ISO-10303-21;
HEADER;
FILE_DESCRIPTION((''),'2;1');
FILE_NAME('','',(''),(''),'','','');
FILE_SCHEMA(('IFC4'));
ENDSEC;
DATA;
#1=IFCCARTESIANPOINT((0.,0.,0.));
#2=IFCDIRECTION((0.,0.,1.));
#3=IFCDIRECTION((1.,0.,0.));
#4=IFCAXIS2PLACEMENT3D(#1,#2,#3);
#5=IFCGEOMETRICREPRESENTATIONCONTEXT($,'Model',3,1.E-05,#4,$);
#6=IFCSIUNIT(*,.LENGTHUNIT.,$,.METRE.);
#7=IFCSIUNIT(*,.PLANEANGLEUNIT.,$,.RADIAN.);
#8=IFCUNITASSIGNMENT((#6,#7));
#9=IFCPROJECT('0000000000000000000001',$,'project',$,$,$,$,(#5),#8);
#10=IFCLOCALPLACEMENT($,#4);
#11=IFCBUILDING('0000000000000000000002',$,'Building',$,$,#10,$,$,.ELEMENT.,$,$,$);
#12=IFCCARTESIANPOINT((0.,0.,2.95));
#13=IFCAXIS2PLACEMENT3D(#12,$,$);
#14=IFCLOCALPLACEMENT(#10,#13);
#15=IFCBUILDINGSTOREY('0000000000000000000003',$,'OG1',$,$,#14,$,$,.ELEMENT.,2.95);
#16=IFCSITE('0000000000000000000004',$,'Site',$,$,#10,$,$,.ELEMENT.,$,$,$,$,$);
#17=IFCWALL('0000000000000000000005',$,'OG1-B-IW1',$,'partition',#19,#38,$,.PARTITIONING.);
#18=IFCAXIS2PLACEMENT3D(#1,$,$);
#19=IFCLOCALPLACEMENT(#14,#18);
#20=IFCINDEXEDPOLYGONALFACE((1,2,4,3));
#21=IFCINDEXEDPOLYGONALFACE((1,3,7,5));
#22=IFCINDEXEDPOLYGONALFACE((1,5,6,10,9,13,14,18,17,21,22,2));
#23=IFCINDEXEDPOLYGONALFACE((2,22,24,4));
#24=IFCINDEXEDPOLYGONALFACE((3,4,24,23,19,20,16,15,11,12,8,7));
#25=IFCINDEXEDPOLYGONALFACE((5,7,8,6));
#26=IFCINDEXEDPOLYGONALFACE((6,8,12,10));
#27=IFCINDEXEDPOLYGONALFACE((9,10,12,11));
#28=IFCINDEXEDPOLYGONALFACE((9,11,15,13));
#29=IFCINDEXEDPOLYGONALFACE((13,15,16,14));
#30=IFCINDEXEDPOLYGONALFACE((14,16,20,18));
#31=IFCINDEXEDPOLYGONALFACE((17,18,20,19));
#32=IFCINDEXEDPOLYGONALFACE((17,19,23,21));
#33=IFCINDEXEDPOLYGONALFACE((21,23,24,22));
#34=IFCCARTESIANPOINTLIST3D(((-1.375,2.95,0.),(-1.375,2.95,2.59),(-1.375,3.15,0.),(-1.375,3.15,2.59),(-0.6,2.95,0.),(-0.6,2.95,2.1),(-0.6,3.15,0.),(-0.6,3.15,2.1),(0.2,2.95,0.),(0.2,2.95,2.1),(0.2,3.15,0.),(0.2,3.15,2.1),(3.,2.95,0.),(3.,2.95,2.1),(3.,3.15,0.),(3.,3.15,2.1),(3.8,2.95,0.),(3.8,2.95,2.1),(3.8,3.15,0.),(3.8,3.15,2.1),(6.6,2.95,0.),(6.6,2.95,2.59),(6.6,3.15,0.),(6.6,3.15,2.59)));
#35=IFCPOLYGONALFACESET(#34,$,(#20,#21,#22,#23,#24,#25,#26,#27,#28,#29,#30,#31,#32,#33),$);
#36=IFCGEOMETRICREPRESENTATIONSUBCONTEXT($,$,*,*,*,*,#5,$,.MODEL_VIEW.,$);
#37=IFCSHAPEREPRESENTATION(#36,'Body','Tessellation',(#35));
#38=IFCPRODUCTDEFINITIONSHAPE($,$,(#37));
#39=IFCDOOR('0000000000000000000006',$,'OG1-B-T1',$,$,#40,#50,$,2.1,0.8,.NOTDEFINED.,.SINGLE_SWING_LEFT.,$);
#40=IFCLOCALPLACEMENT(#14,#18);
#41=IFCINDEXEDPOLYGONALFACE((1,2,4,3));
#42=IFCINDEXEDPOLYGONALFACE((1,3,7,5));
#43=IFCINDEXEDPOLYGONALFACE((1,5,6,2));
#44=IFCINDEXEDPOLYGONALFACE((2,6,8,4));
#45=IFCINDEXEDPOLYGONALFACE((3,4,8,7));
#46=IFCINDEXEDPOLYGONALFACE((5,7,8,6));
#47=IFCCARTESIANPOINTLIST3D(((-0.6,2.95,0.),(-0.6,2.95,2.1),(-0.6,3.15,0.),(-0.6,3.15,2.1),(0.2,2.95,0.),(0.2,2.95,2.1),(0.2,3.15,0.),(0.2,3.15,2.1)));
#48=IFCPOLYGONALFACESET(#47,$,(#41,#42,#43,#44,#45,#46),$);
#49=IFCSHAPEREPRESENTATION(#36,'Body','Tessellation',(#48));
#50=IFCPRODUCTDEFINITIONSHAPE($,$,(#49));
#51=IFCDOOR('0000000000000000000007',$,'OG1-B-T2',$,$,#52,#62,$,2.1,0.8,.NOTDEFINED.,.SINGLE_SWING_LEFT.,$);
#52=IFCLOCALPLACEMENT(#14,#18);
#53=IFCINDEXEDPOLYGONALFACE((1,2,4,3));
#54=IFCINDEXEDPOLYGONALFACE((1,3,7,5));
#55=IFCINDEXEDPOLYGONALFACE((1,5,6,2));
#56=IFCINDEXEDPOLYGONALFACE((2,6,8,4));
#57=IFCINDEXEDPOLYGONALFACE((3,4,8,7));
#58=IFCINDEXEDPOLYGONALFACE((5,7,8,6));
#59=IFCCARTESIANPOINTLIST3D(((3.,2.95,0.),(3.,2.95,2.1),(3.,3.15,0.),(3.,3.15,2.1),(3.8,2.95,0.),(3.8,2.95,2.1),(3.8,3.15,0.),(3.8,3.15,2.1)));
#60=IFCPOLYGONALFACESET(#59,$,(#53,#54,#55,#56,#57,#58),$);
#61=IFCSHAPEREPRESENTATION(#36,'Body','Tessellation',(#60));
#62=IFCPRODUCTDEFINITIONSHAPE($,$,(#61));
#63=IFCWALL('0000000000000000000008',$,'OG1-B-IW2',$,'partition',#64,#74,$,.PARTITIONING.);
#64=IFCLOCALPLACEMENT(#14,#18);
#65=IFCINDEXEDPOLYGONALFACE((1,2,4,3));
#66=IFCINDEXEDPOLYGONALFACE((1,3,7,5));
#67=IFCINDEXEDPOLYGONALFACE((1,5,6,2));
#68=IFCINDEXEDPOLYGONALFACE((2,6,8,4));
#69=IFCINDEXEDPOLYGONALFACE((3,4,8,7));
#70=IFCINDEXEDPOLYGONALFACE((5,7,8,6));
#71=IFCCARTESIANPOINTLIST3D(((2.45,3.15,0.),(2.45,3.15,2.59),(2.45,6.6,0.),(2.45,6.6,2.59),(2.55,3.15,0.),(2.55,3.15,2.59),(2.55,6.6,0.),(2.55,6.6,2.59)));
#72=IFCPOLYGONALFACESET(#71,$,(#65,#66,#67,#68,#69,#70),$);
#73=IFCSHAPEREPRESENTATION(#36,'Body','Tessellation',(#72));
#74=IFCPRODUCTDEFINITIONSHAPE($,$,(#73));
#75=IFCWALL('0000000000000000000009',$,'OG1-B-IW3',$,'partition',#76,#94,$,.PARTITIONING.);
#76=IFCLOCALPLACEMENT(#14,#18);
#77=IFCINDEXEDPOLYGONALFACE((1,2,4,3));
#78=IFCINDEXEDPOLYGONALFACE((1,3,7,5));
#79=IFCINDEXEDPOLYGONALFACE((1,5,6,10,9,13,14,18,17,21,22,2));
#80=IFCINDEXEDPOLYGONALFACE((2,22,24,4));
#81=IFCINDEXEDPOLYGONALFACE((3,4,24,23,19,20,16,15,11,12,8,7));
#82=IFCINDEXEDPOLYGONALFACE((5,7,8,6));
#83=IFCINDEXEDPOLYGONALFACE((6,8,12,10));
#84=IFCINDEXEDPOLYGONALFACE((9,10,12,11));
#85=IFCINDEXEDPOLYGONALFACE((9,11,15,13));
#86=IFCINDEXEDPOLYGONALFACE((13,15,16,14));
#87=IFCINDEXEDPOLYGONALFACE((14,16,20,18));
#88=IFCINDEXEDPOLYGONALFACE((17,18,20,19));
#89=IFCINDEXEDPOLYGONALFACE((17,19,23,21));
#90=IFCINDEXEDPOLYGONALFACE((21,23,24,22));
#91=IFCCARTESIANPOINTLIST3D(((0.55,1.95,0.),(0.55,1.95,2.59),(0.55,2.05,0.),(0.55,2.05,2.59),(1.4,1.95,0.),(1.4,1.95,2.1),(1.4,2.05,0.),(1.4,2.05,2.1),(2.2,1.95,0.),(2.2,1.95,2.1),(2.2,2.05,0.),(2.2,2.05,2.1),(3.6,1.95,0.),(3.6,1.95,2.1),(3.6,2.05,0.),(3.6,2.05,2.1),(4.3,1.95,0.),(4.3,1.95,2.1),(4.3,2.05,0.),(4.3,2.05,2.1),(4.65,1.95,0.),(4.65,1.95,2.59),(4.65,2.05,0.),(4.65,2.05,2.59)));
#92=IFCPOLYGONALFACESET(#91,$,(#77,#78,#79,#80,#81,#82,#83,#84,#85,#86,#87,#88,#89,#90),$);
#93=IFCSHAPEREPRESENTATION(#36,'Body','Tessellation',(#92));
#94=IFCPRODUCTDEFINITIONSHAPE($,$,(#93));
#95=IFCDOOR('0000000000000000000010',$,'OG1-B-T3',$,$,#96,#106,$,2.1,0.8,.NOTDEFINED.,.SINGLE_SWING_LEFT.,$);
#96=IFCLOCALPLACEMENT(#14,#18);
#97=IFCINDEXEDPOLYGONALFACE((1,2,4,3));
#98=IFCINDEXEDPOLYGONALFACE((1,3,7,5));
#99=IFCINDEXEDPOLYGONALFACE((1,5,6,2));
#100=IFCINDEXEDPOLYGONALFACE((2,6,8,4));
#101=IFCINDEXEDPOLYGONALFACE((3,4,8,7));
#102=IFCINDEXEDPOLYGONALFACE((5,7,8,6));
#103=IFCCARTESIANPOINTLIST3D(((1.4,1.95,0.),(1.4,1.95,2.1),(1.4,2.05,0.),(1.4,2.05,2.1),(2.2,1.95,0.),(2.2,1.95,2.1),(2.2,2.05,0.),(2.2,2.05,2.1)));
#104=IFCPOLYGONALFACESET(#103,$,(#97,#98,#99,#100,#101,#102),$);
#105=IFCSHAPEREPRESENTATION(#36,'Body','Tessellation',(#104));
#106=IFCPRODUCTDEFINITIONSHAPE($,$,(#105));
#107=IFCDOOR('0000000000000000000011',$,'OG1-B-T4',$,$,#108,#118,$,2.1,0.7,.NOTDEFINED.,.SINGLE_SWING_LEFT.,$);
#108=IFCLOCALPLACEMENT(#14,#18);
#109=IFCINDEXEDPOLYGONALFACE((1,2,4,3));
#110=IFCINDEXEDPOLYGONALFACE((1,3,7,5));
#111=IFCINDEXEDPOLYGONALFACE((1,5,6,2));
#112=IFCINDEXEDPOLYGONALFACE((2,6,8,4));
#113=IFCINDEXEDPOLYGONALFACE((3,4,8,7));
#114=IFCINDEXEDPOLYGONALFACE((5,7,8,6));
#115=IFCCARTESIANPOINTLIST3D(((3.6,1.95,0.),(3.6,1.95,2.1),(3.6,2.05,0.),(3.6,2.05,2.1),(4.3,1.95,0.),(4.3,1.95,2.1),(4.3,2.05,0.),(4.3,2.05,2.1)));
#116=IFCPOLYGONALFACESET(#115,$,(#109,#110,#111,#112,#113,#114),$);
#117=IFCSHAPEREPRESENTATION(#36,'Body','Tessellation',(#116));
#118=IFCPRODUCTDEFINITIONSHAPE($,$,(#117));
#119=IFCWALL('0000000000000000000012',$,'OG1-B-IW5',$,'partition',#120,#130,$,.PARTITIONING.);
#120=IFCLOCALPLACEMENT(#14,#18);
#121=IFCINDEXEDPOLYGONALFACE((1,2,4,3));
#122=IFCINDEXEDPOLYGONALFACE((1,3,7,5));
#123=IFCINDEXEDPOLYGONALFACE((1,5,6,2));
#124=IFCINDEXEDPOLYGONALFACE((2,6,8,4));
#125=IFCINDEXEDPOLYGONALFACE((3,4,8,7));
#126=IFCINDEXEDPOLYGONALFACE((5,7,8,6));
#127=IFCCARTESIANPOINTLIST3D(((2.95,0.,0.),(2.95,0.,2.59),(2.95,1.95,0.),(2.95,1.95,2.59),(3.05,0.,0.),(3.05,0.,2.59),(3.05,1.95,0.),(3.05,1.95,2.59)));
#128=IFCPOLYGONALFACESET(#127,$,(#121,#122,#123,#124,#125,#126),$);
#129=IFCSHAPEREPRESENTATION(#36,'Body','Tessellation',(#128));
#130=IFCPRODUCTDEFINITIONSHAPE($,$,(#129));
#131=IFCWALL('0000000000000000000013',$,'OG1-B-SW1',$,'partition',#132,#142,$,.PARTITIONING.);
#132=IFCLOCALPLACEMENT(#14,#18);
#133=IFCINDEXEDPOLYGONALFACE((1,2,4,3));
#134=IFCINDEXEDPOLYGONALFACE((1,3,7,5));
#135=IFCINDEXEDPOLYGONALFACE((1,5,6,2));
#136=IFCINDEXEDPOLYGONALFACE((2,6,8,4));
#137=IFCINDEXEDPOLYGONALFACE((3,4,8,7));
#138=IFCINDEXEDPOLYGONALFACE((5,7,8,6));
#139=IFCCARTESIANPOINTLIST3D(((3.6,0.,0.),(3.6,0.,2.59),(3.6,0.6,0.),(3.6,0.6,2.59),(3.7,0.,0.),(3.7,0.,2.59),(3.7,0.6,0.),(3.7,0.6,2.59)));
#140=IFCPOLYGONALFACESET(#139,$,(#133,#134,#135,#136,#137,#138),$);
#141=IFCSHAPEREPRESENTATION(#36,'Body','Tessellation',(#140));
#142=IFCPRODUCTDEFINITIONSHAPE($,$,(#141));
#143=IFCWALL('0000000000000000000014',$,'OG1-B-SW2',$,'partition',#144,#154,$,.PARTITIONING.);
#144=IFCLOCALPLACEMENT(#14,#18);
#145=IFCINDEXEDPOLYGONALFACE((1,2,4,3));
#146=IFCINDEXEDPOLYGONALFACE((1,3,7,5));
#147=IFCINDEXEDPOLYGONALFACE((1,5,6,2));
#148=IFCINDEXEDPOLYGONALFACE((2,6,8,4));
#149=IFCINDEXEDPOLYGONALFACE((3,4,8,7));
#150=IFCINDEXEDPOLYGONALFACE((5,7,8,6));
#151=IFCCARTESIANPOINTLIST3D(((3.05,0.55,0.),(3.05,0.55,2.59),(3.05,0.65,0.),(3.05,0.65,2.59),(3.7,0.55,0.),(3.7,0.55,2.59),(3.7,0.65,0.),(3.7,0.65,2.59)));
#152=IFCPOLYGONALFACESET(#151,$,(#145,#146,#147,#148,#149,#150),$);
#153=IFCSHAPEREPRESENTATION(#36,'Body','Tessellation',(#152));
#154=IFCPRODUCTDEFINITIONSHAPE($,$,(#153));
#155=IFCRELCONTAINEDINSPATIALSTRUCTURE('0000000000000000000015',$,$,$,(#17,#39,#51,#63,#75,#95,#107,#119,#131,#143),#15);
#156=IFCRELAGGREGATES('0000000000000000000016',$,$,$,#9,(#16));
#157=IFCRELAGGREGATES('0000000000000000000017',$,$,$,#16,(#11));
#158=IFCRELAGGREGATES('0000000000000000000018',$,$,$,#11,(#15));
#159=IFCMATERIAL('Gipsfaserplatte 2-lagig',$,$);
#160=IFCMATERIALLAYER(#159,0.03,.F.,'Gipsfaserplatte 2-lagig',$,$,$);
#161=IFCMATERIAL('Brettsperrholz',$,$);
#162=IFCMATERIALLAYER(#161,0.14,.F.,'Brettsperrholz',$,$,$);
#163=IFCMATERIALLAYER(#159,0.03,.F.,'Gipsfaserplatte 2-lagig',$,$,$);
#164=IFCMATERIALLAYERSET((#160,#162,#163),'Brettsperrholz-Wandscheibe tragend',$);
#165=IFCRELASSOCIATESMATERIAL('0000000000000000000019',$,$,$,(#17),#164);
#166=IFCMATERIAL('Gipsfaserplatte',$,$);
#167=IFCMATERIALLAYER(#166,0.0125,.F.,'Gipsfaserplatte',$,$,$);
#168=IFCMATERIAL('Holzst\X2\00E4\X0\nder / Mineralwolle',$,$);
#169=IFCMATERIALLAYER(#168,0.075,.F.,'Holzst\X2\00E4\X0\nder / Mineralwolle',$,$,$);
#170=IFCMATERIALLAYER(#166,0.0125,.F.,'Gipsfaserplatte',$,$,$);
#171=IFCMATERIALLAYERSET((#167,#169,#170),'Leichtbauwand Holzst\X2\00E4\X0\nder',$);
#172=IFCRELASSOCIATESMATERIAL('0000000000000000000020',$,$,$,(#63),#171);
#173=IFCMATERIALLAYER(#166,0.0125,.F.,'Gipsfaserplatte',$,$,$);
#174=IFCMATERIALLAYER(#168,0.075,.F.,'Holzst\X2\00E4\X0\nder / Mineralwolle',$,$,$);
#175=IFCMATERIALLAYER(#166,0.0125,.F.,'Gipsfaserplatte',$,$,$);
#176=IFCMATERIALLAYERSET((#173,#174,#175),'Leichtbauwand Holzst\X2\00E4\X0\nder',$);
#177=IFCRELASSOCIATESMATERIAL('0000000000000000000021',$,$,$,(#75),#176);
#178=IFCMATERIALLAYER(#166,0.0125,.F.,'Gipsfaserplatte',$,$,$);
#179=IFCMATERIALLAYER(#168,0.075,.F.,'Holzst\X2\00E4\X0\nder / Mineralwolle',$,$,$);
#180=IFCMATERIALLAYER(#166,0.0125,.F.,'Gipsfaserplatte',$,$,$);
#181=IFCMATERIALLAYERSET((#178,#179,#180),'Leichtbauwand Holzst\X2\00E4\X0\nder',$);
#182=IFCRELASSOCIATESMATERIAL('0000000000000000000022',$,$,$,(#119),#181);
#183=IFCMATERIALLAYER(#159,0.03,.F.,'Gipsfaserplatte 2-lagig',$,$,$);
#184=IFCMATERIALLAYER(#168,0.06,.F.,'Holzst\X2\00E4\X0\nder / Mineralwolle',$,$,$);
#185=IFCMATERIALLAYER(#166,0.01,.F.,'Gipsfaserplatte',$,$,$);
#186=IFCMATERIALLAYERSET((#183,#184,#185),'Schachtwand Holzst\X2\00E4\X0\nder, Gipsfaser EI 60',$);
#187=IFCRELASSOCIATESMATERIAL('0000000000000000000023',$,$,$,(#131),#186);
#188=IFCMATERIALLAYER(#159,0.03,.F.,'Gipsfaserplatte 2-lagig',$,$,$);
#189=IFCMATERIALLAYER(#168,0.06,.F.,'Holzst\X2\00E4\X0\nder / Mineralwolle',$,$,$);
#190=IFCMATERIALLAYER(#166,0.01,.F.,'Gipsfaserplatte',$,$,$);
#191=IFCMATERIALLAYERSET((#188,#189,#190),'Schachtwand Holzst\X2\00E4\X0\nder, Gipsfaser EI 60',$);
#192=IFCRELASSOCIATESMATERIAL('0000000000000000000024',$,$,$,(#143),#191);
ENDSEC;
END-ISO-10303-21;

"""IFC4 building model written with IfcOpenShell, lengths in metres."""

from ifc_helpers import new_model, si_unit, frame, frame_2d, origin, origin_with_axes, place, context, subcontext, project, spatial, rectangle, extrude, material, layer, layer_set, element, fill, save


model = new_model("IFC4")

# Units and contexts
model_context = context("Model", 3, precision=1e-05, world=origin_with_axes())
sub_context = subcontext(model_context, None, None, "MODEL_VIEW")
ifc_project = project(units=[si_unit("LENGTHUNIT", "METRE"), si_unit("PLANEANGLEUNIT", "RADIAN")], contexts=[model_context])

# Site, building, storey
placement = place(None, origin_with_axes())
site = spatial("IfcSite", under=ifc_project, at=placement, Name="Site", CompositionType="ELEMENT")
building = spatial("IfcBuilding", under=site, at=placement, Name="Building", CompositionType="ELEMENT")
storey_placement = place(placement, frame((0.0, 0.0, 2.95)))
storey = spatial("IfcBuildingStorey", under=building, at=storey_placement, Name="OG1", CompositionType="ELEMENT", Elevation=2.95)

# Shared definitions
ifc_material_1 = material(Name="Gipsfaserplatte")

# Wall, openings, doors
ifc_material_2 = material(Name="Gipsfaserplatte 2-lagig")
ifc_layer_1 = layer(ifc_material_2, 0.03, ventilated=False, Name="Gipsfaserplatte 2-lagig")
ifc_material_3 = material(Name="Brettsperrholz")
ifc_layer_2 = layer(ifc_material_3, 0.14, ventilated=False, Name="Brettsperrholz")
ifc_layer_3 = layer(ifc_material_2, 0.03, ventilated=False, Name="Gipsfaserplatte 2-lagig")
ifc_layer_set_1 = layer_set([ifc_layer_1, ifc_layer_2, ifc_layer_3], Name="Brettsperrholz-Wandscheibe tragend")
wall_1_placement = place(storey_placement, frame((-1.375, 3.05, 0.0), z_axis=(0.0, 0.0, 1.0), x_axis=(1.0, 0.0, 0.0)))
wall_1 = element("IfcWall", 1, at=wall_1_placement, inside=storey, material=ifc_layer_set_1, Name="OG1-B-IW1", ObjectType="partition", PredefinedType="PARTITIONING", context=sub_context, shape_type="SweptSolid", body=[
    extrude(rectangle(XDim=7.975, YDim=0.2, at=frame_2d((3.9875, 0.0))), origin(), (0.0, 0.0, 1.0), 2.59),
])
opening_1_placement = place(wall_1_placement, frame((1.175, 0.15, 0.0), z_axis=(0.0, -1.0, 0.0), x_axis=(1.0, 0.0, 0.0)))
opening_1 = element("IfcOpeningElement", 2, at=opening_1_placement, cuts=wall_1, PredefinedType="OPENING", context=sub_context, shape_type="SweptSolid", body=[
    extrude(rectangle(XDim=0.8, YDim=2.1, at=frame_2d((0.0, 1.05))), origin(), (0.0, 0.0, 1.0), 0.3),
])
opening_2_placement = place(wall_1_placement, frame((4.775, 0.15, 0.0), z_axis=(0.0, -1.0, 0.0), x_axis=(1.0, 0.0, 0.0)))
opening_2 = element("IfcOpeningElement", 3, at=opening_2_placement, cuts=wall_1, PredefinedType="OPENING", context=sub_context, shape_type="SweptSolid", body=[
    extrude(rectangle(XDim=0.8, YDim=2.1, at=frame_2d((0.0, 1.05))), origin(), (0.0, 0.0, 1.0), 0.3),
])
door_1_placement = place(wall_1_placement, frame((1.175, 0.1, 0.0), z_axis=(0.0, -1.0, 0.0), x_axis=(1.0, 0.0, 0.0)))
door_1 = element("IfcDoor", 4, at=door_1_placement, inside=storey, Name="OG1-B-T1", OperationType="SINGLE_SWING_LEFT", OverallHeight=2.1, OverallWidth=0.8, PredefinedType="NOTDEFINED", context=sub_context, shape_type="SweptSolid", body=[
    extrude(rectangle(XDim=0.8, YDim=2.1, at=frame_2d((0.0, 1.05))), origin(), (0.0, 0.0, 1.0), 0.2),
])
fill(opening_1, door_1)
door_2_placement = place(wall_1_placement, frame((4.775, 0.1, 0.0), z_axis=(0.0, -1.0, 0.0), x_axis=(1.0, 0.0, 0.0)))
door_2 = element("IfcDoor", 5, at=door_2_placement, inside=storey, Name="OG1-B-T2", OperationType="SINGLE_SWING_LEFT", OverallHeight=2.1, OverallWidth=0.8, PredefinedType="NOTDEFINED", context=sub_context, shape_type="SweptSolid", body=[
    extrude(rectangle(XDim=0.8, YDim=2.1, at=frame_2d((0.0, 1.05))), origin(), (0.0, 0.0, 1.0), 0.2),
])
fill(opening_2, door_2)

# Wall
ifc_layer_4 = layer(ifc_material_1, 0.0125, ventilated=False, Name="Gipsfaserplatte")
ifc_material_4 = material(Name="Holzständer / Mineralwolle")
ifc_layer_5 = layer(ifc_material_4, 0.075, ventilated=False, Name="Holzständer / Mineralwolle")
ifc_layer_6 = layer(ifc_material_1, 0.0125, ventilated=False, Name="Gipsfaserplatte")
ifc_layer_set_2 = layer_set([ifc_layer_4, ifc_layer_5, ifc_layer_6], Name="Leichtbauwand Holzständer")
wall_2_placement = place(storey_placement, frame((2.5, 3.15, 0.0), z_axis=(0.0, 0.0, 1.0), x_axis=(0.0, 1.0, 0.0)))
element("IfcWall", 6, at=wall_2_placement, inside=storey, material=ifc_layer_set_2, Name="OG1-B-IW2", ObjectType="partition", PredefinedType="PARTITIONING", context=sub_context, shape_type="SweptSolid", body=[
    extrude(rectangle(XDim=3.45, YDim=0.1, at=frame_2d((1.725, 0.0))), origin(), (0.0, 0.0, 1.0), 2.59),
])

# Wall, openings, doors
ifc_layer_7 = layer(ifc_material_1, 0.0125, ventilated=False, Name="Gipsfaserplatte")
ifc_layer_8 = layer(ifc_material_4, 0.075, ventilated=False, Name="Holzständer / Mineralwolle")
ifc_layer_9 = layer(ifc_material_1, 0.0125, ventilated=False, Name="Gipsfaserplatte")
ifc_layer_set_3 = layer_set([ifc_layer_7, ifc_layer_8, ifc_layer_9], Name="Leichtbauwand Holzständer")
wall_3_placement = place(storey_placement, frame((0.55, 2.0, 0.0), z_axis=(0.0, 0.0, 1.0), x_axis=(1.0, 0.0, 0.0)))
wall_3 = element("IfcWall", 7, at=wall_3_placement, inside=storey, material=ifc_layer_set_3, Name="OG1-B-IW3", ObjectType="partition", PredefinedType="PARTITIONING", context=sub_context, shape_type="SweptSolid", body=[
    extrude(rectangle(XDim=4.1, YDim=0.1, at=frame_2d((2.05, 0.0))), origin(), (0.0, 0.0, 1.0), 2.59),
])
opening_3_placement = place(wall_3_placement, frame((1.25, 0.1, 0.0), z_axis=(0.0, -1.0, 0.0), x_axis=(1.0, 0.0, 0.0)))
opening_3 = element("IfcOpeningElement", 8, at=opening_3_placement, cuts=wall_3, PredefinedType="OPENING", context=sub_context, shape_type="SweptSolid", body=[
    extrude(rectangle(XDim=0.8, YDim=2.1, at=frame_2d((0.0, 1.05))), origin(), (0.0, 0.0, 1.0), 0.2),
])
opening_4_placement = place(wall_3_placement, frame((3.4, 0.1, 0.0), z_axis=(0.0, -1.0, 0.0), x_axis=(1.0, 0.0, 0.0)))
opening_4 = element("IfcOpeningElement", 9, at=opening_4_placement, cuts=wall_3, PredefinedType="OPENING", context=sub_context, shape_type="SweptSolid", body=[
    extrude(rectangle(XDim=0.7, YDim=2.1, at=frame_2d((0.0, 1.05))), origin(), (0.0, 0.0, 1.0), 0.2),
])
door_3_placement = place(wall_3_placement, frame((1.25, 0.05, 0.0), z_axis=(0.0, -1.0, 0.0), x_axis=(1.0, 0.0, 0.0)))
door_3 = element("IfcDoor", 10, at=door_3_placement, inside=storey, Name="OG1-B-T3", OperationType="SINGLE_SWING_LEFT", OverallHeight=2.1, OverallWidth=0.8, PredefinedType="NOTDEFINED", context=sub_context, shape_type="SweptSolid", body=[
    extrude(rectangle(XDim=0.8, YDim=2.1, at=frame_2d((0.0, 1.05))), origin(), (0.0, 0.0, 1.0), 0.1),
])
fill(opening_3, door_3)
door_4_placement = place(wall_3_placement, frame((3.4, 0.05, 0.0), z_axis=(0.0, -1.0, 0.0), x_axis=(1.0, 0.0, 0.0)))
door_4 = element("IfcDoor", 11, at=door_4_placement, inside=storey, Name="OG1-B-T4", OperationType="SINGLE_SWING_LEFT", OverallHeight=2.1, OverallWidth=0.7, PredefinedType="NOTDEFINED", context=sub_context, shape_type="SweptSolid", body=[
    extrude(rectangle(XDim=0.7, YDim=2.1, at=frame_2d((0.0, 1.05))), origin(), (0.0, 0.0, 1.0), 0.1),
])
fill(opening_4, door_4)

# Walls
ifc_layer_10 = layer(ifc_material_1, 0.0125, ventilated=False, Name="Gipsfaserplatte")
ifc_layer_11 = layer(ifc_material_4, 0.075, ventilated=False, Name="Holzständer / Mineralwolle")
ifc_layer_12 = layer(ifc_material_1, 0.0125, ventilated=False, Name="Gipsfaserplatte")
ifc_layer_set_4 = layer_set([ifc_layer_10, ifc_layer_11, ifc_layer_12], Name="Leichtbauwand Holzständer")
wall_4_placement = place(storey_placement, frame((3.0, 0.0, 0.0), z_axis=(0.0, 0.0, 1.0), x_axis=(0.0, 1.0, 0.0)))
element("IfcWall", 12, at=wall_4_placement, inside=storey, material=ifc_layer_set_4, Name="OG1-B-IW5", ObjectType="partition", PredefinedType="PARTITIONING", context=sub_context, shape_type="SweptSolid", body=[
    extrude(rectangle(XDim=1.95, YDim=0.1, at=frame_2d((0.975, 0.0))), origin(), (0.0, 0.0, 1.0), 2.59),
])
ifc_layer_13 = layer(ifc_material_2, 0.03, ventilated=False, Name="Gipsfaserplatte 2-lagig")
ifc_layer_14 = layer(ifc_material_4, 0.06, ventilated=False, Name="Holzständer / Mineralwolle")
ifc_layer_15 = layer(ifc_material_1, 0.01, ventilated=False, Name="Gipsfaserplatte")
ifc_layer_set_5 = layer_set([ifc_layer_13, ifc_layer_14, ifc_layer_15], Name="Schachtwand Holzständer, Gipsfaser EI 60")
wall_5_placement = place(storey_placement, frame((3.65, 0.0, 0.0), z_axis=(0.0, 0.0, 1.0), x_axis=(0.0, 1.0, 0.0)))
element("IfcWall", 13, at=wall_5_placement, inside=storey, material=ifc_layer_set_5, Name="OG1-B-SW1", ObjectType="partition", PredefinedType="PARTITIONING", context=sub_context, shape_type="SweptSolid", body=[
    extrude(rectangle(XDim=0.6, YDim=0.1, at=frame_2d((0.3, 0.0))), origin(), (0.0, 0.0, 1.0), 2.59),
])
ifc_layer_16 = layer(ifc_material_2, 0.03, ventilated=False, Name="Gipsfaserplatte 2-lagig")
ifc_layer_17 = layer(ifc_material_4, 0.06, ventilated=False, Name="Holzständer / Mineralwolle")
ifc_layer_18 = layer(ifc_material_1, 0.01, ventilated=False, Name="Gipsfaserplatte")
ifc_layer_set_6 = layer_set([ifc_layer_16, ifc_layer_17, ifc_layer_18], Name="Schachtwand Holzständer, Gipsfaser EI 60")
wall_6_placement = place(storey_placement, frame((3.05, 0.6, 0.0), z_axis=(0.0, 0.0, 1.0), x_axis=(1.0, 0.0, 0.0)))
element("IfcWall", 14, at=wall_6_placement, inside=storey, material=ifc_layer_set_6, Name="OG1-B-SW2", ObjectType="partition", PredefinedType="PARTITIONING", context=sub_context, shape_type="SweptSolid", body=[
    extrude(rectangle(XDim=0.65, YDim=0.1, at=frame_2d((0.325, 0.0))), origin(), (0.0, 0.0, 1.0), 2.59),
])

save(model, "model.ifc")
